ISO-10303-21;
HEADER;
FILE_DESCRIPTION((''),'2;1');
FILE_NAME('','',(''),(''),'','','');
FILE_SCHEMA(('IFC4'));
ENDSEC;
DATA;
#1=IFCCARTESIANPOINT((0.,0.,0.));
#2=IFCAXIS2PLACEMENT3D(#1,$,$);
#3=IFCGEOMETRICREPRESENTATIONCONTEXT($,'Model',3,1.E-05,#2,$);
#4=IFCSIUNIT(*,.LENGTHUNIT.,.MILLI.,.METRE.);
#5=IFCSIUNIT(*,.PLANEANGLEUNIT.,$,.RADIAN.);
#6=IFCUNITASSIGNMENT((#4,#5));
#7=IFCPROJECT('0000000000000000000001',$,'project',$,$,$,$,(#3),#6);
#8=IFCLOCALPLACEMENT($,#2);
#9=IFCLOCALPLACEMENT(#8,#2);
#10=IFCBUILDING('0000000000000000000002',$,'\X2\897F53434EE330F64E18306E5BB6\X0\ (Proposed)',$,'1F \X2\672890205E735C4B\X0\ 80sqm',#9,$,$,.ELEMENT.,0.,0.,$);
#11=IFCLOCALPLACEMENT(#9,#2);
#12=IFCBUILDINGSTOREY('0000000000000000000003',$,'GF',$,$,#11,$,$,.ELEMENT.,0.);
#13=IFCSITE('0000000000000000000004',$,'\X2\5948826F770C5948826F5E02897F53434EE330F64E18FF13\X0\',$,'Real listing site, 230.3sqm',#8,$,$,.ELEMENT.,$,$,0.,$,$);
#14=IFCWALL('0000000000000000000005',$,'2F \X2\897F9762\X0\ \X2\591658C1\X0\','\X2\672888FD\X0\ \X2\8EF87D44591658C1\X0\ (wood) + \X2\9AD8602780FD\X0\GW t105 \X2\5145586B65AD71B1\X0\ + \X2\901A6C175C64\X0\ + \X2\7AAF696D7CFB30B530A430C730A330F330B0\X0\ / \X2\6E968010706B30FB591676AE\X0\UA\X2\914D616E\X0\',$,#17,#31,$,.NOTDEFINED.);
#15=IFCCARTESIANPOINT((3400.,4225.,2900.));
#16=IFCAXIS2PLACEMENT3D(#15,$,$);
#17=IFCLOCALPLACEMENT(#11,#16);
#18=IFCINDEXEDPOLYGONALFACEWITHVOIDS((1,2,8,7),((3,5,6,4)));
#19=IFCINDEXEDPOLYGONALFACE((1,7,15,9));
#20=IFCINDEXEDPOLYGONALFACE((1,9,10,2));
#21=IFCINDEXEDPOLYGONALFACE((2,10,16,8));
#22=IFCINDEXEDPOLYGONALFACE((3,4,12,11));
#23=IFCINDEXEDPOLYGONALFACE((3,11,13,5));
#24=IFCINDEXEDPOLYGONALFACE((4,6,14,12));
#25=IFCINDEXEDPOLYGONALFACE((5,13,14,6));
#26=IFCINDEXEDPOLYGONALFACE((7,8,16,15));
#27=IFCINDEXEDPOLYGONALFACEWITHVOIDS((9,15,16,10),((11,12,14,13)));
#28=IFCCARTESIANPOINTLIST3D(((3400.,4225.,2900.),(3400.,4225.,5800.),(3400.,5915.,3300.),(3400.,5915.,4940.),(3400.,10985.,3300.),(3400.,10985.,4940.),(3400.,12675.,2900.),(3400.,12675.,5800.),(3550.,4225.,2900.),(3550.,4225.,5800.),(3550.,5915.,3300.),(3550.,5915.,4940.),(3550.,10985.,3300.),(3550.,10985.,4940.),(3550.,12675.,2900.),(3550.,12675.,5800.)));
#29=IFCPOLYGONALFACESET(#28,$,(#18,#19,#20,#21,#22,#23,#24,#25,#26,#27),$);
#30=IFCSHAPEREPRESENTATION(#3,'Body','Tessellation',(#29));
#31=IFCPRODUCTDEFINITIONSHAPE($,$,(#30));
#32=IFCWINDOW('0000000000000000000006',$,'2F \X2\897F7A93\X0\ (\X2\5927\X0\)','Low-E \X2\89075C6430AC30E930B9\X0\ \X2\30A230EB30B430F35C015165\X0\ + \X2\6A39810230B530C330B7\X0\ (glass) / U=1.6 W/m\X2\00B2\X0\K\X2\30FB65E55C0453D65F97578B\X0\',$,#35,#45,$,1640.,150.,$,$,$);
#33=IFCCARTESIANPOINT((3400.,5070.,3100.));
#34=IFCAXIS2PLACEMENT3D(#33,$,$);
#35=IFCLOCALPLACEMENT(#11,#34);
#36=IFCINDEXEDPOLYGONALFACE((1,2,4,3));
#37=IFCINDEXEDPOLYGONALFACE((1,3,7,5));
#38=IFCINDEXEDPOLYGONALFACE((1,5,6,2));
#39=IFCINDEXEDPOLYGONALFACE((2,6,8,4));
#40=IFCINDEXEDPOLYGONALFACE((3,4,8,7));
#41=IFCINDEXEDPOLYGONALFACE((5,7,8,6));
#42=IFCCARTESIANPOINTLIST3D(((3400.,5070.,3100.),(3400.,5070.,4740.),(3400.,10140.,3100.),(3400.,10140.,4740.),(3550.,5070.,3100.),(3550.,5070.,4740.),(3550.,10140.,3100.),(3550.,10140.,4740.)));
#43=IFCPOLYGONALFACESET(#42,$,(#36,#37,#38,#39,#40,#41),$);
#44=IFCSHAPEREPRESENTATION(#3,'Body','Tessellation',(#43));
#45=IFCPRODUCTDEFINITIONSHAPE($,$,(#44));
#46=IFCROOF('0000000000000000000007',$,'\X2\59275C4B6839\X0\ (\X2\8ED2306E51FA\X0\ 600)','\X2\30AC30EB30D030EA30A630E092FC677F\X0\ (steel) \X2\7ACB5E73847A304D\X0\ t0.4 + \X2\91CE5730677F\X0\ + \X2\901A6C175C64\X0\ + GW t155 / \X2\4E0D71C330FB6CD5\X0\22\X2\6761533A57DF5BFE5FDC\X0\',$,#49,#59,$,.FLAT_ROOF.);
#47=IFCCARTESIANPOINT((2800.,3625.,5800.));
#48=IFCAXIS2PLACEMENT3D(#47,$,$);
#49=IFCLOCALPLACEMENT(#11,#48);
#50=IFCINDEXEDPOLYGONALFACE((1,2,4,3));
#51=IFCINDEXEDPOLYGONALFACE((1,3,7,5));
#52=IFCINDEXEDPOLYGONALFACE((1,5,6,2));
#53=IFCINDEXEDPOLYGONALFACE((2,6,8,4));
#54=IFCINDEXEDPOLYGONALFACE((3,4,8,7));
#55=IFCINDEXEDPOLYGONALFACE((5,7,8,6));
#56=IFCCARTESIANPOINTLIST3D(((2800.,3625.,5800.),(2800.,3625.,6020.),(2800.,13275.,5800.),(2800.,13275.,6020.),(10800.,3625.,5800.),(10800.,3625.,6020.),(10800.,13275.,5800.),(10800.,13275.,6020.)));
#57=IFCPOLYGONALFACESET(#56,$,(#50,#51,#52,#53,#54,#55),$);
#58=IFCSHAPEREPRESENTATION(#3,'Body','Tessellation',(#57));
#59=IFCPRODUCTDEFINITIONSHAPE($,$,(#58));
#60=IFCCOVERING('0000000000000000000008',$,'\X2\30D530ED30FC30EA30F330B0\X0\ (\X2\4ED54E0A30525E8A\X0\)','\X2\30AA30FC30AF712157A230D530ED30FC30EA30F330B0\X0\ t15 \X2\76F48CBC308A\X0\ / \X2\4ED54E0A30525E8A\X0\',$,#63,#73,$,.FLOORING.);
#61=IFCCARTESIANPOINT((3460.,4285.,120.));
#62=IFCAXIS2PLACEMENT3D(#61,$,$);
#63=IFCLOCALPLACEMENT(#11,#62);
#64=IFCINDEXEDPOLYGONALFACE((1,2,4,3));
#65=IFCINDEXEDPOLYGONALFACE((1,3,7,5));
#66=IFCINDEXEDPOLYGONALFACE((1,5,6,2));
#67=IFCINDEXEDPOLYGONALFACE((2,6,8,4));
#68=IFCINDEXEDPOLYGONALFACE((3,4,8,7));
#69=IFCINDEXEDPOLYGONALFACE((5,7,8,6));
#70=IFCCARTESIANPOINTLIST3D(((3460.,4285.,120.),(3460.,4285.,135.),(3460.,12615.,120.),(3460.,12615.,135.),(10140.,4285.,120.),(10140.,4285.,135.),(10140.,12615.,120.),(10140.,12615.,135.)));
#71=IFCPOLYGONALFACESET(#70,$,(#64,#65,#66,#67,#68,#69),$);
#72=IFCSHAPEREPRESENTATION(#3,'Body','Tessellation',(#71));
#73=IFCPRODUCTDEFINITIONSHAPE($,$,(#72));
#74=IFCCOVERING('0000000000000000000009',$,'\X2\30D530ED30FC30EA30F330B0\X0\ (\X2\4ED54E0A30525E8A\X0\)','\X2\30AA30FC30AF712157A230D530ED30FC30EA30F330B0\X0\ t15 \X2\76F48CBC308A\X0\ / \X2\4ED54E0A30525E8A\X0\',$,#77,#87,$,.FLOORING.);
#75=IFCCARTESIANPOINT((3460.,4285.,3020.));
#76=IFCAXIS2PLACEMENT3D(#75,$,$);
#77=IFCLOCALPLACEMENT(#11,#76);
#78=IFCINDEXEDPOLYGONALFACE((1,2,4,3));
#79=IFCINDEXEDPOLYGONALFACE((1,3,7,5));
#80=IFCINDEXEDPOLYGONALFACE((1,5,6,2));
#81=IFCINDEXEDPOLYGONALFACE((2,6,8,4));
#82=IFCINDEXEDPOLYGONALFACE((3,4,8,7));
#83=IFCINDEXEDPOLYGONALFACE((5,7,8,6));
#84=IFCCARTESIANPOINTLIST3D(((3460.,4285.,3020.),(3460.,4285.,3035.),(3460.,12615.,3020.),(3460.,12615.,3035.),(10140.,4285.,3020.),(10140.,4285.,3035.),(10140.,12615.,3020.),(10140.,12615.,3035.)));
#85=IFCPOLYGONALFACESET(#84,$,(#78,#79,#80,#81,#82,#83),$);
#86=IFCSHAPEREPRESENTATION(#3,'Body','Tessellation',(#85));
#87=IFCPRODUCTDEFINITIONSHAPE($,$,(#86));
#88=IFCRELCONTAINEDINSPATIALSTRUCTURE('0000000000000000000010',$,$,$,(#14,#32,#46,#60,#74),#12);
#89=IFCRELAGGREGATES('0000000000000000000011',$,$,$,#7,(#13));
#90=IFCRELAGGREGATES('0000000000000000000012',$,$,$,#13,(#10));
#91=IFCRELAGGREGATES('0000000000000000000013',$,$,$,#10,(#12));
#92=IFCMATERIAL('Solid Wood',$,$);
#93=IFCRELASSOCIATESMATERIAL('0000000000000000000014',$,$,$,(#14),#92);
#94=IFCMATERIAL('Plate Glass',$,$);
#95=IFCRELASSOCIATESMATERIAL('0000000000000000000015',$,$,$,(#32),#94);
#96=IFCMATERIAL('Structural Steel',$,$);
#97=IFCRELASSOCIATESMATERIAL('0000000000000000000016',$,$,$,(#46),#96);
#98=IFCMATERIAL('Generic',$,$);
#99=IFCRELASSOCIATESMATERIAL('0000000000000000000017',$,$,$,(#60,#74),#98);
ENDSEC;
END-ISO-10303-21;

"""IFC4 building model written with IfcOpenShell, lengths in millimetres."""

from ifc_helpers import new_model, si_unit, frame, frame_2d, origin, place, context, project, spatial, rectangle, extrude, material, element, fill, save


model = new_model("IFC4")

# Units and contexts
model_context = context("Model", 3, precision=1e-05, world=origin())
ifc_project = project(units=[si_unit("LENGTHUNIT", "METRE", prefix="MILLI"), si_unit("PLANEANGLEUNIT", "RADIAN")], contexts=[model_context])

# Site, building, storey
site_placement = place(None, origin())
site = spatial("IfcSite", under=ifc_project, at=site_placement, Name="奈良県奈良市西千代ヶ丘３", ObjectType="Real listing site, 230.3sqm", CompositionType="ELEMENT", RefElevation=0.0)
building_placement = place(site_placement, origin())
building = spatial("IfcBuilding", under=site, at=building_placement, Name="西千代ヶ丘の家 (Proposed)", ObjectType="1F 木造平屋 80sqm", CompositionType="ELEMENT", ElevationOfRefHeight=0.0, ElevationOfTerrain=0.0)
storey_placement = place(building_placement, origin())
storey = spatial("IfcBuildingStorey", under=building, at=storey_placement, Name="GF", CompositionType="ELEMENT", Elevation=0.0)

# Shared definitions
ifc_material_1 = material(Name="Solid Wood")
ifc_material_2 = material(Name="Generic")

# Shared definitions
ifc_material_3 = material(Name="Plate Glass")

# Wall, opening, window
wall_1_placement = place(storey_placement, frame((3400.0, 4225.0, 2900.0)))
wall_1 = element("IfcWall", 1, at=wall_1_placement, inside=storey, material=ifc_material_1, Name="2F 西面 外壁", Description="木製 軸組外壁 (wood) + 高性能GW t105 充填断熱 + 通気層 + 窯業系サイディング / 準耐火・外皮UA配慮", PredefinedType="NOTDEFINED", context=model_context, shape_type="SweptSolid", body=[
    extrude(rectangle(XDim=150.0, YDim=8450.0, at=frame_2d((75.0, 4225.0))), frame((3400.0, 4225.0, 2900.0)), (0.0, 0.0, 1.0), 2900.0),
])
opening_1_placement = place(storey_placement, frame((3400.0, 5070.0, 3100.0)))
opening_1 = element("IfcOpeningElement", 2, at=opening_1_placement, cuts=wall_1, PredefinedType="NOTDEFINED", context=model_context, shape_type="SweptSolid", body=[
    extrude(rectangle(XDim=150.0, YDim=5070.0, at=frame_2d((75.0, 2535.0))), frame((3400.0, 5070.0, 3100.0)), (0.0, 0.0, 1.0), 1640.0),
])
window_1_placement = place(storey_placement, frame((3400.0, 5070.0, 3100.0)))
window_1 = element("IfcWindow", 3, at=window_1_placement, inside=storey, material=ifc_material_3, Name="2F 西窓 (大)", Description="Low-E 複層ガラス アルゴン封入 + 樹脂サッシ (glass) / U=1.6 W/m²K・日射取得型", OverallHeight=1640.0, OverallWidth=150.0, context=model_context, shape_type="SweptSolid", body=[
    extrude(rectangle(XDim=150.0, YDim=5070.0, at=frame_2d((75.0, 2535.0))), frame((3400.0, 5070.0, 3100.0)), (0.0, 0.0, 1.0), 1640.0),
])
fill(opening_1, window_1)

# Roof
ifc_material_4 = material(Name="Structural Steel")
roof_placement = place(storey_placement, frame((2800.0, 3625.0, 5800.0)))
element("IfcRoof", 4, at=roof_placement, inside=storey, material=ifc_material_4, Name="大屋根 (軒の出 600)", Description="ガルバリウム鋼板 (steel) 立平葺き t0.4 + 野地板 + 通気層 + GW t155 / 不燃・法22条区域対応", PredefinedType="FLAT_ROOF", context=model_context, shape_type="SweptSolid", body=[
    extrude(rectangle(XDim=8000.0, YDim=9650.0, at=frame_2d((4000.0, 4825.0))), frame((2800.0, 3625.0, 5800.0)), (0.0, 0.0, 1.0), 220.0),
])

# Coverings
covering_1_placement = place(storey_placement, frame((3460.0, 4285.0, 120.0)))
element("IfcCovering", 5, at=covering_1_placement, inside=storey, material=ifc_material_2, Name="フローリング (仕上げ床)", Description="オーク無垢フローリング t15 直貼り / 仕上げ床", PredefinedType="FLOORING", context=model_context, shape_type="SweptSolid", body=[
    extrude(rectangle(XDim=6680.0, YDim=8330.0, at=frame_2d((3340.0, 4165.0))), frame((3460.0, 4285.0, 120.0)), (0.0, 0.0, 1.0), 15.0),
])
covering_2_placement = place(storey_placement, frame((3460.0, 4285.0, 3020.0)))
element("IfcCovering", 6, at=covering_2_placement, inside=storey, material=ifc_material_2, Name="フローリング (仕上げ床)", Description="オーク無垢フローリング t15 直貼り / 仕上げ床", PredefinedType="FLOORING", context=model_context, shape_type="SweptSolid", body=[
    extrude(rectangle(XDim=6680.0, YDim=8330.0, at=frame_2d((3340.0, 4165.0))), frame((3460.0, 4285.0, 3020.0)), (0.0, 0.0, 1.0), 15.0),
])

save(model, "model.ifc")
